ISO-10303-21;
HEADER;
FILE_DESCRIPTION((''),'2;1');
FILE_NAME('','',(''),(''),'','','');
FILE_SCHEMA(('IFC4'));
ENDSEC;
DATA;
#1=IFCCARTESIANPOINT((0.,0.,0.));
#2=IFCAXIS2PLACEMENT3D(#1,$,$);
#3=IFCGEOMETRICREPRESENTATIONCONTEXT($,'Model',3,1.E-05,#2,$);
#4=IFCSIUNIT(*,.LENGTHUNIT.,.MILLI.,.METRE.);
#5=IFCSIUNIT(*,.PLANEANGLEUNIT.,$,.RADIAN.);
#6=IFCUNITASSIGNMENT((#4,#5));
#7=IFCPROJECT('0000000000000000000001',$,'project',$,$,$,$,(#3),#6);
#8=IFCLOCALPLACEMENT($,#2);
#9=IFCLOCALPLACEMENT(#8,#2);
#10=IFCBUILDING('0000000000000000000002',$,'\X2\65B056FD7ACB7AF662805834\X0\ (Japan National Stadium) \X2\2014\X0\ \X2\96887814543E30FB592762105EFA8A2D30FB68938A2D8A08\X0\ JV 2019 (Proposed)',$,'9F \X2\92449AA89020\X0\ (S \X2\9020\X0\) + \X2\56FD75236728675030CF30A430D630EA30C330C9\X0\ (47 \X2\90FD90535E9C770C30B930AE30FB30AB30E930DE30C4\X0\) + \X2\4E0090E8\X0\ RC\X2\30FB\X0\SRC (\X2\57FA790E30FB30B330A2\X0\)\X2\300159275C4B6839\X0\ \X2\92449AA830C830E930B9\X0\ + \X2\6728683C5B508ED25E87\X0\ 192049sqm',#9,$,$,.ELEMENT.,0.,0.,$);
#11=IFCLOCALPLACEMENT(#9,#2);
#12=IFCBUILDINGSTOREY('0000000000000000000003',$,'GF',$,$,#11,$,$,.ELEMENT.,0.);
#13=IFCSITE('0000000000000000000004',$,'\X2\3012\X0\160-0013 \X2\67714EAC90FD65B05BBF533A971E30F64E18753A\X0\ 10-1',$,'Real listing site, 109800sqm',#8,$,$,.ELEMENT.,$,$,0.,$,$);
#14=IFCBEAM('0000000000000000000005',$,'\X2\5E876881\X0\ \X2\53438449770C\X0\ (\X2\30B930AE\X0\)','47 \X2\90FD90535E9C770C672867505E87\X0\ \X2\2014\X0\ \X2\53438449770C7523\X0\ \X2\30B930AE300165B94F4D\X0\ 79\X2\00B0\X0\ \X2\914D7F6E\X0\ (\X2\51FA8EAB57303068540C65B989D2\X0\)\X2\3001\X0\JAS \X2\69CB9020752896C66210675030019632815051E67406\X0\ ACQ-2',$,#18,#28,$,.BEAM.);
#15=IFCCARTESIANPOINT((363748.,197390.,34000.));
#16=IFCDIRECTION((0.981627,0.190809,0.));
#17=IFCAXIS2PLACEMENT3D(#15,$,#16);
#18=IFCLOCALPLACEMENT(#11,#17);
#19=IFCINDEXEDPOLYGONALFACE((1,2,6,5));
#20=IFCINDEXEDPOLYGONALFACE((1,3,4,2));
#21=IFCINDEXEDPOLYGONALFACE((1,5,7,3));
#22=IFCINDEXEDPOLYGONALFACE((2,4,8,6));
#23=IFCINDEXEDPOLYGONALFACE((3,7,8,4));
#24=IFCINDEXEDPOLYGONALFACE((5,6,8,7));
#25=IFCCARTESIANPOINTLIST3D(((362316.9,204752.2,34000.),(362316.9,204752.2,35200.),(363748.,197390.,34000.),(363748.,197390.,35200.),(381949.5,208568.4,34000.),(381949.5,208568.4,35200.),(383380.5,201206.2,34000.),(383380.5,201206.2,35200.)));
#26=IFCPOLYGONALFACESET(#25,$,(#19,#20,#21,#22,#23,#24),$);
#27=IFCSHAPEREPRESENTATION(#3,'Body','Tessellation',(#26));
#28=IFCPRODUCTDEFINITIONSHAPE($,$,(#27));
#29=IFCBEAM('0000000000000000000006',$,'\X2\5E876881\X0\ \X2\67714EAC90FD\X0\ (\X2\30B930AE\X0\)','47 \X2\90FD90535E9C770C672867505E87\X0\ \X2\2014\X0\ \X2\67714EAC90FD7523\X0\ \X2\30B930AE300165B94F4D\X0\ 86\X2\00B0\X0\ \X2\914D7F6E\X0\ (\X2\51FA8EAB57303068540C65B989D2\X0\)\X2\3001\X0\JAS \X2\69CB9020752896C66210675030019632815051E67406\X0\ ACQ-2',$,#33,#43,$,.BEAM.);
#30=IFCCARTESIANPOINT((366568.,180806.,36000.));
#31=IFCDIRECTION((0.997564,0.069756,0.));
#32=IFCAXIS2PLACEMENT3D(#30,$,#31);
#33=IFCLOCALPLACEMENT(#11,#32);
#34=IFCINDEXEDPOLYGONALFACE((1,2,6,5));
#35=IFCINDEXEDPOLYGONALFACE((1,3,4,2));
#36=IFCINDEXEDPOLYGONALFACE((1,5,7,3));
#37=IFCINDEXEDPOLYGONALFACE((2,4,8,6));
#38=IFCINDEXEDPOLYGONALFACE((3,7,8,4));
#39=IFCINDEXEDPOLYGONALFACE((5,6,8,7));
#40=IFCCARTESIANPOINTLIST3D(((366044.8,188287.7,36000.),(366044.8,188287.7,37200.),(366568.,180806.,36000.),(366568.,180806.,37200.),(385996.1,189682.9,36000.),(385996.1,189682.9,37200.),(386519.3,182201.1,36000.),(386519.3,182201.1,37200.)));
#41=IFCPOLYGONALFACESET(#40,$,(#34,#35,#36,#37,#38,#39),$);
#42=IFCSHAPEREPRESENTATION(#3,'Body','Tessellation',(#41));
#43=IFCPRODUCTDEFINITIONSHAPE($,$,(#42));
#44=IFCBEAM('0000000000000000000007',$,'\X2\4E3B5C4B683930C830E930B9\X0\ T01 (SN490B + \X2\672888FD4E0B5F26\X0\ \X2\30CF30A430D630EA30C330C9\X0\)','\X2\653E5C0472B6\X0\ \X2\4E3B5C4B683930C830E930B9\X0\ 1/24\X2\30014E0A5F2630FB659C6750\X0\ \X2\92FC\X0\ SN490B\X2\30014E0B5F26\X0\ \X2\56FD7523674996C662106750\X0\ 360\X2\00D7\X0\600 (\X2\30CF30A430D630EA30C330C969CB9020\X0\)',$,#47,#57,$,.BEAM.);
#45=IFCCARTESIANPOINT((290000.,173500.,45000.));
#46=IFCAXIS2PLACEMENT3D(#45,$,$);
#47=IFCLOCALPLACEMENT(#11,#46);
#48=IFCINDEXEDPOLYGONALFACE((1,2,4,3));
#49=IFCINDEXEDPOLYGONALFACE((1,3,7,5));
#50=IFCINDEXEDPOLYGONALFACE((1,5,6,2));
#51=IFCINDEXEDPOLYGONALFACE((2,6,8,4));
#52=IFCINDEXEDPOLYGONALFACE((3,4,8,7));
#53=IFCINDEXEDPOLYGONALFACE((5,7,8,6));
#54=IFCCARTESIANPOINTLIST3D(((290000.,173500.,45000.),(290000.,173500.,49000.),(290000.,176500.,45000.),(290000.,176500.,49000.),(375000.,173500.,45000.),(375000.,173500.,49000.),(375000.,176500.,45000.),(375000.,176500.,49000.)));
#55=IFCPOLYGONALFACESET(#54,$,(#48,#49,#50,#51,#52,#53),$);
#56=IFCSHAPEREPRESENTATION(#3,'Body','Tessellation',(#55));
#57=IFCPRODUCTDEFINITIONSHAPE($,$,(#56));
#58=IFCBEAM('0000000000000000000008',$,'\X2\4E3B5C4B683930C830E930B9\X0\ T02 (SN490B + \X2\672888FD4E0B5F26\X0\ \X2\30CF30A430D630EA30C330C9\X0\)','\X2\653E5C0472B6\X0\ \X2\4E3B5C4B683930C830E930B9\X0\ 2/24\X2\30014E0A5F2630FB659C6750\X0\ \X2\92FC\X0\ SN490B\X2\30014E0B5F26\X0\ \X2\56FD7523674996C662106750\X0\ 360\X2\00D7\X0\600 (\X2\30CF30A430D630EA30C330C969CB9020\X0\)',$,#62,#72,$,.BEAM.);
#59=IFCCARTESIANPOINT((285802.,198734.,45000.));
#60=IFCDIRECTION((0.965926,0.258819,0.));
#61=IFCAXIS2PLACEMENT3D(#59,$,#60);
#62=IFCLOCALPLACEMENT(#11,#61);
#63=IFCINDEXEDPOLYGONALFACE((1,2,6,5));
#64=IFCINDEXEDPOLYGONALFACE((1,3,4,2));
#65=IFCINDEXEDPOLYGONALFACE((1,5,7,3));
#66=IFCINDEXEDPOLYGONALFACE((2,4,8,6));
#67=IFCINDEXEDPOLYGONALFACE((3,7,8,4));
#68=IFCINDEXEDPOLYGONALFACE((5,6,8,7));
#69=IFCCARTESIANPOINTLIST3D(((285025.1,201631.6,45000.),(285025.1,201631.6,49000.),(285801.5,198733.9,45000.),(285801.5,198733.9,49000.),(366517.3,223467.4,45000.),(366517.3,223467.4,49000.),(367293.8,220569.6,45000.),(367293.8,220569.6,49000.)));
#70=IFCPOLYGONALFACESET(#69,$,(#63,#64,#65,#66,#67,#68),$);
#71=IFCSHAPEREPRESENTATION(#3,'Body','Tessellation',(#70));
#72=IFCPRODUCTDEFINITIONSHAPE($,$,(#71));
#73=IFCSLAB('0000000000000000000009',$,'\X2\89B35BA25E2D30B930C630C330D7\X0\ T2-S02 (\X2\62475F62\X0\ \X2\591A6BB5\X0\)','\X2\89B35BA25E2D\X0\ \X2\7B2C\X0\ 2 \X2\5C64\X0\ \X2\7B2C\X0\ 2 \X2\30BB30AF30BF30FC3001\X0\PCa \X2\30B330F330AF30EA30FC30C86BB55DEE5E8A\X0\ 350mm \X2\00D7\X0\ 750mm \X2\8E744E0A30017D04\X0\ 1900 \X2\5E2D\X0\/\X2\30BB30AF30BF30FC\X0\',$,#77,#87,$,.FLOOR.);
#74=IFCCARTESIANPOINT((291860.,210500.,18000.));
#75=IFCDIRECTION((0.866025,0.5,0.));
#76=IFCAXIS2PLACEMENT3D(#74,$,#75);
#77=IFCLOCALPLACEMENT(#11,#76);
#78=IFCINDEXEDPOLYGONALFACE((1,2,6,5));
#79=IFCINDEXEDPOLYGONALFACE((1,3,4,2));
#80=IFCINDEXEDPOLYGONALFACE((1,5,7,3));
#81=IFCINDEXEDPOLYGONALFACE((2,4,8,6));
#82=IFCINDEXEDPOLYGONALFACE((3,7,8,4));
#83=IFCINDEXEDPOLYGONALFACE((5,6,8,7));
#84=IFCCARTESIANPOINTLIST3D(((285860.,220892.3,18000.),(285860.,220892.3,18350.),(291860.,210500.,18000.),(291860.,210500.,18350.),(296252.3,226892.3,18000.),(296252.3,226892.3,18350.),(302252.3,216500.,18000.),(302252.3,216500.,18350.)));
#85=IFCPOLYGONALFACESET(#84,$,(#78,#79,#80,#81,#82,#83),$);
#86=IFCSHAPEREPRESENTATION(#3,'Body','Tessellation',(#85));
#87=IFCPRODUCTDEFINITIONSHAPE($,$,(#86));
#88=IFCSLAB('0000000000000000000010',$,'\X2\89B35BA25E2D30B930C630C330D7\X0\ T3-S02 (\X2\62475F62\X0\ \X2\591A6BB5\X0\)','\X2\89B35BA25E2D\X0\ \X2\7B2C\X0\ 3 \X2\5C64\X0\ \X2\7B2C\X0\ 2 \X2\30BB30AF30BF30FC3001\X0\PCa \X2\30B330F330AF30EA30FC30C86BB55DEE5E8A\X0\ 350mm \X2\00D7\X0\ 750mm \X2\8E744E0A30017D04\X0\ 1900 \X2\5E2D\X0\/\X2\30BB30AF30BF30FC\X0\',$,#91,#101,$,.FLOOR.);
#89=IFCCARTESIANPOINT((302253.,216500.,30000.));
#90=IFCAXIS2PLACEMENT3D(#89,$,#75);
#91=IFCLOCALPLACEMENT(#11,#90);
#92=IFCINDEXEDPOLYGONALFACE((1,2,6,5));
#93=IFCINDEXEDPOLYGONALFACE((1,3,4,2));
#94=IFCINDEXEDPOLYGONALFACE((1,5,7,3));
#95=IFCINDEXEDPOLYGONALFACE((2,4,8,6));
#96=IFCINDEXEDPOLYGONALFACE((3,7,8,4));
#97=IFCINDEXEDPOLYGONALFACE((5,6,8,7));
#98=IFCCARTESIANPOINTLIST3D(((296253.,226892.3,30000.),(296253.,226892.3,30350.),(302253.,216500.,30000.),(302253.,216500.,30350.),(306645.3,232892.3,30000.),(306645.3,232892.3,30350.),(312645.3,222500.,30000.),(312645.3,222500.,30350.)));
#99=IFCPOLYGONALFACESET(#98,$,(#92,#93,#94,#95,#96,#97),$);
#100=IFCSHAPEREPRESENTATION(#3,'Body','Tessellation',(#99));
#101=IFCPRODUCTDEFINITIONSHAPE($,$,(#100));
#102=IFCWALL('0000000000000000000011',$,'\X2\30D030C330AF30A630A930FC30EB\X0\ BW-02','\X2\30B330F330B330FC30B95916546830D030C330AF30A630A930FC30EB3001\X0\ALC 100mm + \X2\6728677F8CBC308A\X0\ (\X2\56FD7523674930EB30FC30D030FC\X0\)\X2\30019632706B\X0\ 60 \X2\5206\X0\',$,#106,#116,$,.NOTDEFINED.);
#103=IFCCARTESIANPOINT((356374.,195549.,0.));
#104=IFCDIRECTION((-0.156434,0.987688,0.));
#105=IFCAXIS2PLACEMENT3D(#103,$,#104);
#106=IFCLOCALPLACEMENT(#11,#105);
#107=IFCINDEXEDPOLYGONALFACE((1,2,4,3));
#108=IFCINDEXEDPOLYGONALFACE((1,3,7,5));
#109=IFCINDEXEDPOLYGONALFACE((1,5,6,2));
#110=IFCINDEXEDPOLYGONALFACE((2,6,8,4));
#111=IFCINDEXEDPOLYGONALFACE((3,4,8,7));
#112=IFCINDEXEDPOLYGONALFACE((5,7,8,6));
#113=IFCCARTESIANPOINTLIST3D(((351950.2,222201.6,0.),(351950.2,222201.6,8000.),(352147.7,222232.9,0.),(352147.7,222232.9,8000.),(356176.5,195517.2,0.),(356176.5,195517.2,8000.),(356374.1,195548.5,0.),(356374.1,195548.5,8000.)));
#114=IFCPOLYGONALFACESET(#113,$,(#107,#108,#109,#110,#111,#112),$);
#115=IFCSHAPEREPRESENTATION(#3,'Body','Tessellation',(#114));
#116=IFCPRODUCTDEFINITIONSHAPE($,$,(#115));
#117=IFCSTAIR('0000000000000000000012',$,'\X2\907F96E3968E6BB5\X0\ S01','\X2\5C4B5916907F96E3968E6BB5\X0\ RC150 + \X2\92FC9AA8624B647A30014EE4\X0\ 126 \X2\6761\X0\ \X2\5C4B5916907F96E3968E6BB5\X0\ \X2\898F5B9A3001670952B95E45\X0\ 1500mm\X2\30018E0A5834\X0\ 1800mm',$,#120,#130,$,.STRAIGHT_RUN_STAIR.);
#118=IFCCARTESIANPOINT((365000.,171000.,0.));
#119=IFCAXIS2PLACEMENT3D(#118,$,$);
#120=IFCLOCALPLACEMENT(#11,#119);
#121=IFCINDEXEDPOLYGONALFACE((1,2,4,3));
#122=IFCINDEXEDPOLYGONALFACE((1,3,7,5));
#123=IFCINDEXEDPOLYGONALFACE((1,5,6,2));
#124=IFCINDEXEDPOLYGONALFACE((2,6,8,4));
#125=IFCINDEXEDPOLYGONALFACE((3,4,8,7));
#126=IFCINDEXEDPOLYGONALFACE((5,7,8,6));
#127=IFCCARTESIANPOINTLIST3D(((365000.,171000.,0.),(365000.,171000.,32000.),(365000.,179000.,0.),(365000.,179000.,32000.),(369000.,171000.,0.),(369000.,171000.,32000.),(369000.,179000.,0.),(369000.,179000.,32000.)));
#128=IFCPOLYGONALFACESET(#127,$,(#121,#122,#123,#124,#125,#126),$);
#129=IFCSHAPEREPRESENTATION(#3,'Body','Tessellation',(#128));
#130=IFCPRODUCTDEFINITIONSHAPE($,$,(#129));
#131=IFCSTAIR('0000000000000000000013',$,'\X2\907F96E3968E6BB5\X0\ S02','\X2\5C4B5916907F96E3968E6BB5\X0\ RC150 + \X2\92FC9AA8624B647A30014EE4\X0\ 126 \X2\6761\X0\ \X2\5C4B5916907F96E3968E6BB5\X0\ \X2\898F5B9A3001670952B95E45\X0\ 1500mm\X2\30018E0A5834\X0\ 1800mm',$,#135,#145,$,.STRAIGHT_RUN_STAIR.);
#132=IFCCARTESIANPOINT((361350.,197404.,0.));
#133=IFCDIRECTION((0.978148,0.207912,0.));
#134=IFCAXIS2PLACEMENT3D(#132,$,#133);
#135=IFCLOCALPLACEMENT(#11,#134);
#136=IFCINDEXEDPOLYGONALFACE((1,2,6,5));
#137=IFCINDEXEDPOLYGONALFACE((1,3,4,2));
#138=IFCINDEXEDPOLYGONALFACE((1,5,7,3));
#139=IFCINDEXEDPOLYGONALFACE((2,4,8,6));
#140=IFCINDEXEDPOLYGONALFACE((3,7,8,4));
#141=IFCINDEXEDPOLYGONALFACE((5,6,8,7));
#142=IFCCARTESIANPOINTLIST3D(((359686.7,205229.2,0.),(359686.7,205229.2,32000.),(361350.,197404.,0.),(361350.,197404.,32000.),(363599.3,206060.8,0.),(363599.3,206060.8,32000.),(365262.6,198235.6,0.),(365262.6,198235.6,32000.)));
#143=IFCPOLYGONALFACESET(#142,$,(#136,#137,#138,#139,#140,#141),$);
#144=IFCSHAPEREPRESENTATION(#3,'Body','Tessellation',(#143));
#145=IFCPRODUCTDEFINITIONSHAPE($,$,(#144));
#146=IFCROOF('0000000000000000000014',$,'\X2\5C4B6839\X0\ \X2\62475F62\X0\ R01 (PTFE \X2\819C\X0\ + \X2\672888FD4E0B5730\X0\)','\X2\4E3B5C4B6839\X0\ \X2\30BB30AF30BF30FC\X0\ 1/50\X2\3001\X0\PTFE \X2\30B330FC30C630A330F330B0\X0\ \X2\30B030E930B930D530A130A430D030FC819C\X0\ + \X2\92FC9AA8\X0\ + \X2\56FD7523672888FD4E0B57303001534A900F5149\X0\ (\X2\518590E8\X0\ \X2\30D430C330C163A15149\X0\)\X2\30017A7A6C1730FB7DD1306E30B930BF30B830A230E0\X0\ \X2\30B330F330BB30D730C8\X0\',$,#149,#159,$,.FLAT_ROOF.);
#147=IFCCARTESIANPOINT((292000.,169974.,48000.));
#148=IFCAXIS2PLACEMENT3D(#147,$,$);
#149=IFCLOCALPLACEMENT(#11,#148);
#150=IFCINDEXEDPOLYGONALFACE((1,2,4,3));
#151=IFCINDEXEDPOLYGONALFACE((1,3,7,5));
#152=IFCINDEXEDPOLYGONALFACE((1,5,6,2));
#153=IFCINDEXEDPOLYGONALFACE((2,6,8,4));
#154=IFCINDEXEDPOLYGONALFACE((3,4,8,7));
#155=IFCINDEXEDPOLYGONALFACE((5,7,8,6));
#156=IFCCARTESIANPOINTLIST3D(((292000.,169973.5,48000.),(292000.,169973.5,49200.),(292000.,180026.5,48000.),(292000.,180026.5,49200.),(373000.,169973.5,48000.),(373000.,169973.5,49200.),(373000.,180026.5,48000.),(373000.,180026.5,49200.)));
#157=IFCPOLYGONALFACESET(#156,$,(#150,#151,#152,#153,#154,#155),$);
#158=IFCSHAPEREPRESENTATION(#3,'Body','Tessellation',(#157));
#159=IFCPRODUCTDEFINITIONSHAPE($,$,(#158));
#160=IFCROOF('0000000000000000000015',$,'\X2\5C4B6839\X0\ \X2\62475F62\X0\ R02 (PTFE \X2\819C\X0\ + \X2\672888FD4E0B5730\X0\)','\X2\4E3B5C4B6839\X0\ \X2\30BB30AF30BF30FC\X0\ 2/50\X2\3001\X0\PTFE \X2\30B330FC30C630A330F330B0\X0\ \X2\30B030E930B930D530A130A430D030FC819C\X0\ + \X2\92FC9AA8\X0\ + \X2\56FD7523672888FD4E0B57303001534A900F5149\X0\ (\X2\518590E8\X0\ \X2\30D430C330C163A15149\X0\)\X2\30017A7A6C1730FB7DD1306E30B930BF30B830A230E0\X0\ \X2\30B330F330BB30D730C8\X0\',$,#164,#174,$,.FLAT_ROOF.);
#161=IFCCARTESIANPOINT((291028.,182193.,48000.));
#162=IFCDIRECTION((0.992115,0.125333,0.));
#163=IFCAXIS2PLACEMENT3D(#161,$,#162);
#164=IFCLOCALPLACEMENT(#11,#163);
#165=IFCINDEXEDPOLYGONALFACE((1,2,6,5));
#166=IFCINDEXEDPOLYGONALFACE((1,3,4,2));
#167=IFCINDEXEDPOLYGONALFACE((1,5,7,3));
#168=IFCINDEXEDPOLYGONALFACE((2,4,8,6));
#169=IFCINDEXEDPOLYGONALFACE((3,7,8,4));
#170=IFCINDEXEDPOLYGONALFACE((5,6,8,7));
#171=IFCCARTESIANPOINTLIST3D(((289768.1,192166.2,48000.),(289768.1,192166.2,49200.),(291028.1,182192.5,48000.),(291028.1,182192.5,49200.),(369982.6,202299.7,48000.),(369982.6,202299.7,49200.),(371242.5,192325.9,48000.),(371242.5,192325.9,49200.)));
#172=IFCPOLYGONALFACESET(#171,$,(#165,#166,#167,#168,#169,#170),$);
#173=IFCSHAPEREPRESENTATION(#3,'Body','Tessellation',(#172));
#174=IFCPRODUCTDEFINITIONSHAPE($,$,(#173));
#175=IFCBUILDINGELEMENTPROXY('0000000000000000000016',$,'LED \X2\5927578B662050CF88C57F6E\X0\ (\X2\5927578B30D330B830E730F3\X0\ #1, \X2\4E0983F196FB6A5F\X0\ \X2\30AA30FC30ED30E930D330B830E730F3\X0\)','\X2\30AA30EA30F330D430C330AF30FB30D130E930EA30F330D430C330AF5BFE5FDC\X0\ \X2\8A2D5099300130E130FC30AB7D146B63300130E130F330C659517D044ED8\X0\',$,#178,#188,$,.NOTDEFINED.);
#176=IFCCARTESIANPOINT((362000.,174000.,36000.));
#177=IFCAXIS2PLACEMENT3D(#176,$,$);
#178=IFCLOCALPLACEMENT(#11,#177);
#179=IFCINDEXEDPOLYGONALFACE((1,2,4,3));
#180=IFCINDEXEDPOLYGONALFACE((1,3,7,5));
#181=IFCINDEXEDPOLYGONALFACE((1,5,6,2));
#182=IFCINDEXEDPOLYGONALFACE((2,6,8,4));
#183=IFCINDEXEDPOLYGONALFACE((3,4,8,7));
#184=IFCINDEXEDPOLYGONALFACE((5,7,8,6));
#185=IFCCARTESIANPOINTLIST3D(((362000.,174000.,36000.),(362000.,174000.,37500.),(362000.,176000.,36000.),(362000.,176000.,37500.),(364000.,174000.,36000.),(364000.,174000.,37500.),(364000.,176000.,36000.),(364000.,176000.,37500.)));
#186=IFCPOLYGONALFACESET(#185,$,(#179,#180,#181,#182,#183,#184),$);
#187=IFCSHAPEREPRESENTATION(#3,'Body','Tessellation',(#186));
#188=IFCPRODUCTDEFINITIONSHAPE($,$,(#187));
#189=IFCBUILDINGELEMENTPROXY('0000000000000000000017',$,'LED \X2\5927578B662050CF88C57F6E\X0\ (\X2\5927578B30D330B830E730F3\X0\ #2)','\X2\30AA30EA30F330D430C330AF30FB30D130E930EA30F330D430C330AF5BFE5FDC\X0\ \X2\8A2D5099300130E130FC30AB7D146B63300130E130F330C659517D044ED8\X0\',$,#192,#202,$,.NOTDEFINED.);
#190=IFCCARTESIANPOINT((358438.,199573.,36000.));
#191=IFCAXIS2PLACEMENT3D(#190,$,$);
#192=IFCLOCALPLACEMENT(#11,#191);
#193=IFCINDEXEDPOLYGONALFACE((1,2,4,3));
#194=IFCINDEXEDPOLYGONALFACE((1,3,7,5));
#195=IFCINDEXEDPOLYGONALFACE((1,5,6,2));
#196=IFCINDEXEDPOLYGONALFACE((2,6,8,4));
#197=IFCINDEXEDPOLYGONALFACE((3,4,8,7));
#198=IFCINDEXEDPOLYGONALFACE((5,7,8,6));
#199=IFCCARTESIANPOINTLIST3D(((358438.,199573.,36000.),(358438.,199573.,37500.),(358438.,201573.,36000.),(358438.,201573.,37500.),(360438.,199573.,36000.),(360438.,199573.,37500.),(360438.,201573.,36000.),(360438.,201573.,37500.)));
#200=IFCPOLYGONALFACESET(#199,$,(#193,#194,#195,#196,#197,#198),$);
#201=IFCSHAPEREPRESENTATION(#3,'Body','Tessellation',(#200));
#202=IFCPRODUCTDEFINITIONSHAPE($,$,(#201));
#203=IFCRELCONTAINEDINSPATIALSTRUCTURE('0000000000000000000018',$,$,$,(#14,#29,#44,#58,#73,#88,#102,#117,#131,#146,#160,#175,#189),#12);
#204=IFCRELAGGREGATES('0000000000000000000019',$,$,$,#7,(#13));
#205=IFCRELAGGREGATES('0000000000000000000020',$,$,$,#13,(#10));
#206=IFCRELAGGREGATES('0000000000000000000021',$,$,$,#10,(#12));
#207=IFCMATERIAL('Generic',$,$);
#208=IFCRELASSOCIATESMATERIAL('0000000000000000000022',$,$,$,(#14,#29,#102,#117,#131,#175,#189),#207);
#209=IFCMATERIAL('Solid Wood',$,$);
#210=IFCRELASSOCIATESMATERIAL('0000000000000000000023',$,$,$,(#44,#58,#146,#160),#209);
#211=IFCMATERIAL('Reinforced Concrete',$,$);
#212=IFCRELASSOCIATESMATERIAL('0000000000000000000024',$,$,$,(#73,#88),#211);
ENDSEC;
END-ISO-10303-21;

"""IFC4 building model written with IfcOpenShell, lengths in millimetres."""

from ifc_helpers import new_model, si_unit, frame, frame_2d, origin, place, context, project, spatial, rectangle, extrude, material, element, save


model = new_model("IFC4")

# Units and contexts
model_context = context("Model", 3, precision=1e-05, world=origin())
ifc_project = project(units=[si_unit("LENGTHUNIT", "METRE", prefix="MILLI"), si_unit("PLANEANGLEUNIT", "RADIAN")], contexts=[model_context])

# Site, building, storey
site_placement = place(None, origin())
site = spatial("IfcSite", under=ifc_project, at=site_placement, Name="〒160-0013 東京都新宿区霞ヶ丘町 10-1", ObjectType="Real listing site, 109800sqm", CompositionType="ELEMENT", RefElevation=0.0)
building_placement = place(site_placement, origin())
building = spatial("IfcBuilding", under=site, at=building_placement, Name="新国立競技場 (Japan National Stadium) — 隈研吾・大成建設・梓設計 JV 2019 (Proposed)", ObjectType="9F 鉄骨造 (S 造) + 国産木材ハイブリッド (47 都道府県スギ・カラマツ) + 一部 RC・SRC (基礎・コア)、大屋根 鉄骨トラス + 木格子軒庇 192049sqm", CompositionType="ELEMENT", ElevationOfRefHeight=0.0, ElevationOfTerrain=0.0)
storey_placement = place(building_placement, origin())
storey = spatial("IfcBuildingStorey", under=building, at=storey_placement, Name="GF", CompositionType="ELEMENT", Elevation=0.0)

# Shared definitions
ifc_material_1 = material(Name="Reinforced Concrete")

# Shared definitions
ifc_material_2 = material(Name="Generic")

# Beams
beam_1_placement = place(storey_placement, frame((363748.0, 197390.0, 34000.0), x_axis=(0.981627, 0.190809, 0.0)))
element("IfcBeam", 1, at=beam_1_placement, inside=storey, material=ifc_material_2, Name="庇梁 千葉県 (スギ)", Description="47 都道府県木材庇 — 千葉県産 スギ、方位 79° 配置 (出身地と同方角)、JAS 構造用集成材、防腐処理 ACQ-2", PredefinedType="BEAM", context=model_context, shape_type="SweptSolid", body=[
    extrude(rectangle(XDim=20000.0, YDim=7500.0, at=frame_2d((10000.0, 3750.0))), frame((363748.0, 197390.0, 34000.0), x_axis=(0.981627, 0.190809, 0.0)), (0.0, 0.0, 1.0), 1200.0),
])
beam_2_placement = place(storey_placement, frame((366568.0, 180806.0, 36000.0), x_axis=(0.997564, 0.069756, 0.0)))
element("IfcBeam", 2, at=beam_2_placement, inside=storey, material=ifc_material_2, Name="庇梁 東京都 (スギ)", Description="47 都道府県木材庇 — 東京都産 スギ、方位 86° 配置 (出身地と同方角)、JAS 構造用集成材、防腐処理 ACQ-2", PredefinedType="BEAM", context=model_context, shape_type="SweptSolid", body=[
    extrude(rectangle(XDim=20000.0, YDim=7500.0, at=frame_2d((10000.0, 3750.0))), frame((366568.0, 180806.0, 36000.0), x_axis=(0.997564, 0.069756, 0.0)), (0.0, 0.0, 1.0), 1200.0),
])
ifc_material_3 = material(Name="Solid Wood")
beam_3_placement = place(storey_placement, frame((290000.0, 173500.0, 45000.0)))
element("IfcBeam", 3, at=beam_3_placement, inside=storey, material=ifc_material_3, Name="主屋根トラス T01 (SN490B + 木製下弦 ハイブリッド)", Description="放射状 主屋根トラス 1/24、上弦・斜材 鋼 SN490B、下弦 国産杉集成材 360×600 (ハイブリッド構造)", PredefinedType="BEAM", context=model_context, shape_type="SweptSolid", body=[
    extrude(rectangle(XDim=85000.0, YDim=3000.0, at=frame_2d((42500.0, 1500.0))), frame((290000.0, 173500.0, 45000.0)), (0.0, 0.0, 1.0), 4000.0),
])
beam_4_placement = place(storey_placement, frame((285802.0, 198734.0, 45000.0), x_axis=(0.965926, 0.258819, 0.0)))
element("IfcBeam", 4, at=beam_4_placement, inside=storey, material=ifc_material_3, Name="主屋根トラス T02 (SN490B + 木製下弦 ハイブリッド)", Description="放射状 主屋根トラス 2/24、上弦・斜材 鋼 SN490B、下弦 国産杉集成材 360×600 (ハイブリッド構造)", PredefinedType="BEAM", context=model_context, shape_type="SweptSolid", body=[
    extrude(rectangle(XDim=84367.0, YDim=3000.0, at=frame_2d((42183.0, 1500.0))), frame((285802.0, 198734.0, 45000.0), x_axis=(0.965926, 0.258819, 0.0)), (0.0, 0.0, 1.0), 4000.0),
])

# Slabs
slab_1_placement = place(storey_placement, frame((291860.0, 210500.0, 18000.0), x_axis=(0.866025, 0.5, 0.0)))
element("IfcSlab", 5, at=slab_1_placement, inside=storey, material=ifc_material_1, Name="観客席ステップ T2-S02 (扇形 多段)", Description="観客席 第 2 層 第 2 セクター、PCa コンクリート段差床 350mm × 750mm 蹴上、約 1900 席/セクター", PredefinedType="FLOOR", context=model_context, shape_type="SweptSolid", body=[
    extrude(rectangle(XDim=12000.0, YDim=12000.0, at=frame_2d((6000.0, 6000.0))), frame((291860.0, 210500.0, 18000.0), x_axis=(0.866025, 0.5, 0.0)), (0.0, 0.0, 1.0), 350.0),
])
slab_2_placement = place(storey_placement, frame((302253.0, 216500.0, 30000.0), x_axis=(0.866025, 0.5, 0.0)))
element("IfcSlab", 6, at=slab_2_placement, inside=storey, material=ifc_material_1, Name="観客席ステップ T3-S02 (扇形 多段)", Description="観客席 第 3 層 第 2 セクター、PCa コンクリート段差床 350mm × 750mm 蹴上、約 1900 席/セクター", PredefinedType="FLOOR", context=model_context, shape_type="SweptSolid", body=[
    extrude(rectangle(XDim=12000.0, YDim=12000.0, at=frame_2d((6000.0, 6000.0))), frame((302253.0, 216500.0, 30000.0), x_axis=(0.866025, 0.5, 0.0)), (0.0, 0.0, 1.0), 350.0),
])

# Wall
wall_1_placement = place(storey_placement, frame((356374.0, 195549.0, 0.0), x_axis=(-0.156434, 0.987688, 0.0)))
element("IfcWall", 7, at=wall_1_placement, inside=storey, material=ifc_material_2, Name="バックウォール BW-02", Description="コンコース外周バックウォール、ALC 100mm + 木板貼り (国産杉ルーバー)、防火 60 分", PredefinedType="NOTDEFINED", context=model_context, shape_type="SweptSolid", body=[
    extrude(rectangle(XDim=27017.0, YDim=200.0, at=frame_2d((13508.0, 100.0))), frame((356374.0, 195549.0, 0.0), x_axis=(-0.156434, 0.987688, 0.0)), (0.0, 0.0, 1.0), 8000.0),
])

# Stairs
stair_1_placement = place(storey_placement, frame((365000.0, 171000.0, 0.0)))
element("IfcStair", 8, at=stair_1_placement, inside=storey, material=ifc_material_2, Name="避難階段 S01", Description="屋外避難階段 RC150 + 鋼骨手摺、令 126 条 屋外避難階段 規定、有効幅 1500mm、踊場 1800mm", PredefinedType="STRAIGHT_RUN_STAIR", context=model_context, shape_type="SweptSolid", body=[
    extrude(rectangle(XDim=4000.0, YDim=8000.0, at=frame_2d((2000.0, 4000.0))), frame((365000.0, 171000.0, 0.0)), (0.0, 0.0, 1.0), 32000.0),
])
stair_2_placement = place(storey_placement, frame((361350.0, 197404.0, 0.0), x_axis=(0.978148, 0.207912, 0.0)))
element("IfcStair", 9, at=stair_2_placement, inside=storey, material=ifc_material_2, Name="避難階段 S02", Description="屋外避難階段 RC150 + 鋼骨手摺、令 126 条 屋外避難階段 規定、有効幅 1500mm、踊場 1800mm", PredefinedType="STRAIGHT_RUN_STAIR", context=model_context, shape_type="SweptSolid", body=[
    extrude(rectangle(XDim=4000.0, YDim=8000.0, at=frame_2d((2000.0, 4000.0))), frame((361350.0, 197404.0, 0.0), x_axis=(0.978148, 0.207912, 0.0)), (0.0, 0.0, 1.0), 32000.0),
])

# Roofs
roof_1_placement = place(storey_placement, frame((292000.0, 169974.0, 48000.0)))
element("IfcRoof", 10, at=roof_1_placement, inside=storey, material=ifc_material_3, Name="屋根 扇形 R01 (PTFE 膜 + 木製下地)", Description="主屋根 セクター 1/50、PTFE コーティング グラスファイバー膜 + 鋼骨 + 国産木製下地、半透光 (内部 ピッチ採光)、空気・緑のスタジアム コンセプト", PredefinedType="FLAT_ROOF", context=model_context, shape_type="SweptSolid", body=[
    extrude(rectangle(XDim=81000.0, YDim=10053.0, at=frame_2d((40500.0, 5026.0))), frame((292000.0, 169974.0, 48000.0)), (0.0, 0.0, 1.0), 1200.0),
])
roof_2_placement = place(storey_placement, frame((291028.0, 182193.0, 48000.0), x_axis=(0.992115, 0.125333, 0.0)))
element("IfcRoof", 11, at=roof_2_placement, inside=storey, material=ifc_material_3, Name="屋根 扇形 R02 (PTFE 膜 + 木製下地)", Description="主屋根 セクター 2/50、PTFE コーティング グラスファイバー膜 + 鋼骨 + 国産木製下地、半透光 (内部 ピッチ採光)、空気・緑のスタジアム コンセプト", PredefinedType="FLAT_ROOF", context=model_context, shape_type="SweptSolid", body=[
    extrude(rectangle(XDim=80852.0, YDim=10053.0, at=frame_2d((40426.0, 5026.0))), frame((291028.0, 182193.0, 48000.0), x_axis=(0.992115, 0.125333, 0.0)), (0.0, 0.0, 1.0), 1200.0),
])

# Building element proxies
proxy_1_placement = place(storey_placement, frame((362000.0, 174000.0, 36000.0)))
element("IfcBuildingElementProxy", 12, at=proxy_1_placement, inside=storey, material=ifc_material_2, Name="LED 大型映像装置 (大型ビジョン #1, 三菱電機 オーロラビジョン)", Description="オリンピック・パラリンピック対応 設備、メーカ純正、メンテ契約付", PredefinedType="NOTDEFINED", context=model_context, shape_type="SweptSolid", body=[
    extrude(rectangle(XDim=2000.0, YDim=2000.0, at=frame_2d((1000.0, 1000.0))), frame((362000.0, 174000.0, 36000.0)), (0.0, 0.0, 1.0), 1500.0),
])
proxy_2_placement = place(storey_placement, frame((358438.0, 199573.0, 36000.0)))
element("IfcBuildingElementProxy", 13, at=proxy_2_placement, inside=storey, material=ifc_material_2, Name="LED 大型映像装置 (大型ビジョン #2)", Description="オリンピック・パラリンピック対応 設備、メーカ純正、メンテ契約付", PredefinedType="NOTDEFINED", context=model_context, shape_type="SweptSolid", body=[
    extrude(rectangle(XDim=2000.0, YDim=2000.0, at=frame_2d((1000.0, 1000.0))), frame((358438.0, 199573.0, 36000.0)), (0.0, 0.0, 1.0), 1500.0),
])

save(model, "model.ifc")
